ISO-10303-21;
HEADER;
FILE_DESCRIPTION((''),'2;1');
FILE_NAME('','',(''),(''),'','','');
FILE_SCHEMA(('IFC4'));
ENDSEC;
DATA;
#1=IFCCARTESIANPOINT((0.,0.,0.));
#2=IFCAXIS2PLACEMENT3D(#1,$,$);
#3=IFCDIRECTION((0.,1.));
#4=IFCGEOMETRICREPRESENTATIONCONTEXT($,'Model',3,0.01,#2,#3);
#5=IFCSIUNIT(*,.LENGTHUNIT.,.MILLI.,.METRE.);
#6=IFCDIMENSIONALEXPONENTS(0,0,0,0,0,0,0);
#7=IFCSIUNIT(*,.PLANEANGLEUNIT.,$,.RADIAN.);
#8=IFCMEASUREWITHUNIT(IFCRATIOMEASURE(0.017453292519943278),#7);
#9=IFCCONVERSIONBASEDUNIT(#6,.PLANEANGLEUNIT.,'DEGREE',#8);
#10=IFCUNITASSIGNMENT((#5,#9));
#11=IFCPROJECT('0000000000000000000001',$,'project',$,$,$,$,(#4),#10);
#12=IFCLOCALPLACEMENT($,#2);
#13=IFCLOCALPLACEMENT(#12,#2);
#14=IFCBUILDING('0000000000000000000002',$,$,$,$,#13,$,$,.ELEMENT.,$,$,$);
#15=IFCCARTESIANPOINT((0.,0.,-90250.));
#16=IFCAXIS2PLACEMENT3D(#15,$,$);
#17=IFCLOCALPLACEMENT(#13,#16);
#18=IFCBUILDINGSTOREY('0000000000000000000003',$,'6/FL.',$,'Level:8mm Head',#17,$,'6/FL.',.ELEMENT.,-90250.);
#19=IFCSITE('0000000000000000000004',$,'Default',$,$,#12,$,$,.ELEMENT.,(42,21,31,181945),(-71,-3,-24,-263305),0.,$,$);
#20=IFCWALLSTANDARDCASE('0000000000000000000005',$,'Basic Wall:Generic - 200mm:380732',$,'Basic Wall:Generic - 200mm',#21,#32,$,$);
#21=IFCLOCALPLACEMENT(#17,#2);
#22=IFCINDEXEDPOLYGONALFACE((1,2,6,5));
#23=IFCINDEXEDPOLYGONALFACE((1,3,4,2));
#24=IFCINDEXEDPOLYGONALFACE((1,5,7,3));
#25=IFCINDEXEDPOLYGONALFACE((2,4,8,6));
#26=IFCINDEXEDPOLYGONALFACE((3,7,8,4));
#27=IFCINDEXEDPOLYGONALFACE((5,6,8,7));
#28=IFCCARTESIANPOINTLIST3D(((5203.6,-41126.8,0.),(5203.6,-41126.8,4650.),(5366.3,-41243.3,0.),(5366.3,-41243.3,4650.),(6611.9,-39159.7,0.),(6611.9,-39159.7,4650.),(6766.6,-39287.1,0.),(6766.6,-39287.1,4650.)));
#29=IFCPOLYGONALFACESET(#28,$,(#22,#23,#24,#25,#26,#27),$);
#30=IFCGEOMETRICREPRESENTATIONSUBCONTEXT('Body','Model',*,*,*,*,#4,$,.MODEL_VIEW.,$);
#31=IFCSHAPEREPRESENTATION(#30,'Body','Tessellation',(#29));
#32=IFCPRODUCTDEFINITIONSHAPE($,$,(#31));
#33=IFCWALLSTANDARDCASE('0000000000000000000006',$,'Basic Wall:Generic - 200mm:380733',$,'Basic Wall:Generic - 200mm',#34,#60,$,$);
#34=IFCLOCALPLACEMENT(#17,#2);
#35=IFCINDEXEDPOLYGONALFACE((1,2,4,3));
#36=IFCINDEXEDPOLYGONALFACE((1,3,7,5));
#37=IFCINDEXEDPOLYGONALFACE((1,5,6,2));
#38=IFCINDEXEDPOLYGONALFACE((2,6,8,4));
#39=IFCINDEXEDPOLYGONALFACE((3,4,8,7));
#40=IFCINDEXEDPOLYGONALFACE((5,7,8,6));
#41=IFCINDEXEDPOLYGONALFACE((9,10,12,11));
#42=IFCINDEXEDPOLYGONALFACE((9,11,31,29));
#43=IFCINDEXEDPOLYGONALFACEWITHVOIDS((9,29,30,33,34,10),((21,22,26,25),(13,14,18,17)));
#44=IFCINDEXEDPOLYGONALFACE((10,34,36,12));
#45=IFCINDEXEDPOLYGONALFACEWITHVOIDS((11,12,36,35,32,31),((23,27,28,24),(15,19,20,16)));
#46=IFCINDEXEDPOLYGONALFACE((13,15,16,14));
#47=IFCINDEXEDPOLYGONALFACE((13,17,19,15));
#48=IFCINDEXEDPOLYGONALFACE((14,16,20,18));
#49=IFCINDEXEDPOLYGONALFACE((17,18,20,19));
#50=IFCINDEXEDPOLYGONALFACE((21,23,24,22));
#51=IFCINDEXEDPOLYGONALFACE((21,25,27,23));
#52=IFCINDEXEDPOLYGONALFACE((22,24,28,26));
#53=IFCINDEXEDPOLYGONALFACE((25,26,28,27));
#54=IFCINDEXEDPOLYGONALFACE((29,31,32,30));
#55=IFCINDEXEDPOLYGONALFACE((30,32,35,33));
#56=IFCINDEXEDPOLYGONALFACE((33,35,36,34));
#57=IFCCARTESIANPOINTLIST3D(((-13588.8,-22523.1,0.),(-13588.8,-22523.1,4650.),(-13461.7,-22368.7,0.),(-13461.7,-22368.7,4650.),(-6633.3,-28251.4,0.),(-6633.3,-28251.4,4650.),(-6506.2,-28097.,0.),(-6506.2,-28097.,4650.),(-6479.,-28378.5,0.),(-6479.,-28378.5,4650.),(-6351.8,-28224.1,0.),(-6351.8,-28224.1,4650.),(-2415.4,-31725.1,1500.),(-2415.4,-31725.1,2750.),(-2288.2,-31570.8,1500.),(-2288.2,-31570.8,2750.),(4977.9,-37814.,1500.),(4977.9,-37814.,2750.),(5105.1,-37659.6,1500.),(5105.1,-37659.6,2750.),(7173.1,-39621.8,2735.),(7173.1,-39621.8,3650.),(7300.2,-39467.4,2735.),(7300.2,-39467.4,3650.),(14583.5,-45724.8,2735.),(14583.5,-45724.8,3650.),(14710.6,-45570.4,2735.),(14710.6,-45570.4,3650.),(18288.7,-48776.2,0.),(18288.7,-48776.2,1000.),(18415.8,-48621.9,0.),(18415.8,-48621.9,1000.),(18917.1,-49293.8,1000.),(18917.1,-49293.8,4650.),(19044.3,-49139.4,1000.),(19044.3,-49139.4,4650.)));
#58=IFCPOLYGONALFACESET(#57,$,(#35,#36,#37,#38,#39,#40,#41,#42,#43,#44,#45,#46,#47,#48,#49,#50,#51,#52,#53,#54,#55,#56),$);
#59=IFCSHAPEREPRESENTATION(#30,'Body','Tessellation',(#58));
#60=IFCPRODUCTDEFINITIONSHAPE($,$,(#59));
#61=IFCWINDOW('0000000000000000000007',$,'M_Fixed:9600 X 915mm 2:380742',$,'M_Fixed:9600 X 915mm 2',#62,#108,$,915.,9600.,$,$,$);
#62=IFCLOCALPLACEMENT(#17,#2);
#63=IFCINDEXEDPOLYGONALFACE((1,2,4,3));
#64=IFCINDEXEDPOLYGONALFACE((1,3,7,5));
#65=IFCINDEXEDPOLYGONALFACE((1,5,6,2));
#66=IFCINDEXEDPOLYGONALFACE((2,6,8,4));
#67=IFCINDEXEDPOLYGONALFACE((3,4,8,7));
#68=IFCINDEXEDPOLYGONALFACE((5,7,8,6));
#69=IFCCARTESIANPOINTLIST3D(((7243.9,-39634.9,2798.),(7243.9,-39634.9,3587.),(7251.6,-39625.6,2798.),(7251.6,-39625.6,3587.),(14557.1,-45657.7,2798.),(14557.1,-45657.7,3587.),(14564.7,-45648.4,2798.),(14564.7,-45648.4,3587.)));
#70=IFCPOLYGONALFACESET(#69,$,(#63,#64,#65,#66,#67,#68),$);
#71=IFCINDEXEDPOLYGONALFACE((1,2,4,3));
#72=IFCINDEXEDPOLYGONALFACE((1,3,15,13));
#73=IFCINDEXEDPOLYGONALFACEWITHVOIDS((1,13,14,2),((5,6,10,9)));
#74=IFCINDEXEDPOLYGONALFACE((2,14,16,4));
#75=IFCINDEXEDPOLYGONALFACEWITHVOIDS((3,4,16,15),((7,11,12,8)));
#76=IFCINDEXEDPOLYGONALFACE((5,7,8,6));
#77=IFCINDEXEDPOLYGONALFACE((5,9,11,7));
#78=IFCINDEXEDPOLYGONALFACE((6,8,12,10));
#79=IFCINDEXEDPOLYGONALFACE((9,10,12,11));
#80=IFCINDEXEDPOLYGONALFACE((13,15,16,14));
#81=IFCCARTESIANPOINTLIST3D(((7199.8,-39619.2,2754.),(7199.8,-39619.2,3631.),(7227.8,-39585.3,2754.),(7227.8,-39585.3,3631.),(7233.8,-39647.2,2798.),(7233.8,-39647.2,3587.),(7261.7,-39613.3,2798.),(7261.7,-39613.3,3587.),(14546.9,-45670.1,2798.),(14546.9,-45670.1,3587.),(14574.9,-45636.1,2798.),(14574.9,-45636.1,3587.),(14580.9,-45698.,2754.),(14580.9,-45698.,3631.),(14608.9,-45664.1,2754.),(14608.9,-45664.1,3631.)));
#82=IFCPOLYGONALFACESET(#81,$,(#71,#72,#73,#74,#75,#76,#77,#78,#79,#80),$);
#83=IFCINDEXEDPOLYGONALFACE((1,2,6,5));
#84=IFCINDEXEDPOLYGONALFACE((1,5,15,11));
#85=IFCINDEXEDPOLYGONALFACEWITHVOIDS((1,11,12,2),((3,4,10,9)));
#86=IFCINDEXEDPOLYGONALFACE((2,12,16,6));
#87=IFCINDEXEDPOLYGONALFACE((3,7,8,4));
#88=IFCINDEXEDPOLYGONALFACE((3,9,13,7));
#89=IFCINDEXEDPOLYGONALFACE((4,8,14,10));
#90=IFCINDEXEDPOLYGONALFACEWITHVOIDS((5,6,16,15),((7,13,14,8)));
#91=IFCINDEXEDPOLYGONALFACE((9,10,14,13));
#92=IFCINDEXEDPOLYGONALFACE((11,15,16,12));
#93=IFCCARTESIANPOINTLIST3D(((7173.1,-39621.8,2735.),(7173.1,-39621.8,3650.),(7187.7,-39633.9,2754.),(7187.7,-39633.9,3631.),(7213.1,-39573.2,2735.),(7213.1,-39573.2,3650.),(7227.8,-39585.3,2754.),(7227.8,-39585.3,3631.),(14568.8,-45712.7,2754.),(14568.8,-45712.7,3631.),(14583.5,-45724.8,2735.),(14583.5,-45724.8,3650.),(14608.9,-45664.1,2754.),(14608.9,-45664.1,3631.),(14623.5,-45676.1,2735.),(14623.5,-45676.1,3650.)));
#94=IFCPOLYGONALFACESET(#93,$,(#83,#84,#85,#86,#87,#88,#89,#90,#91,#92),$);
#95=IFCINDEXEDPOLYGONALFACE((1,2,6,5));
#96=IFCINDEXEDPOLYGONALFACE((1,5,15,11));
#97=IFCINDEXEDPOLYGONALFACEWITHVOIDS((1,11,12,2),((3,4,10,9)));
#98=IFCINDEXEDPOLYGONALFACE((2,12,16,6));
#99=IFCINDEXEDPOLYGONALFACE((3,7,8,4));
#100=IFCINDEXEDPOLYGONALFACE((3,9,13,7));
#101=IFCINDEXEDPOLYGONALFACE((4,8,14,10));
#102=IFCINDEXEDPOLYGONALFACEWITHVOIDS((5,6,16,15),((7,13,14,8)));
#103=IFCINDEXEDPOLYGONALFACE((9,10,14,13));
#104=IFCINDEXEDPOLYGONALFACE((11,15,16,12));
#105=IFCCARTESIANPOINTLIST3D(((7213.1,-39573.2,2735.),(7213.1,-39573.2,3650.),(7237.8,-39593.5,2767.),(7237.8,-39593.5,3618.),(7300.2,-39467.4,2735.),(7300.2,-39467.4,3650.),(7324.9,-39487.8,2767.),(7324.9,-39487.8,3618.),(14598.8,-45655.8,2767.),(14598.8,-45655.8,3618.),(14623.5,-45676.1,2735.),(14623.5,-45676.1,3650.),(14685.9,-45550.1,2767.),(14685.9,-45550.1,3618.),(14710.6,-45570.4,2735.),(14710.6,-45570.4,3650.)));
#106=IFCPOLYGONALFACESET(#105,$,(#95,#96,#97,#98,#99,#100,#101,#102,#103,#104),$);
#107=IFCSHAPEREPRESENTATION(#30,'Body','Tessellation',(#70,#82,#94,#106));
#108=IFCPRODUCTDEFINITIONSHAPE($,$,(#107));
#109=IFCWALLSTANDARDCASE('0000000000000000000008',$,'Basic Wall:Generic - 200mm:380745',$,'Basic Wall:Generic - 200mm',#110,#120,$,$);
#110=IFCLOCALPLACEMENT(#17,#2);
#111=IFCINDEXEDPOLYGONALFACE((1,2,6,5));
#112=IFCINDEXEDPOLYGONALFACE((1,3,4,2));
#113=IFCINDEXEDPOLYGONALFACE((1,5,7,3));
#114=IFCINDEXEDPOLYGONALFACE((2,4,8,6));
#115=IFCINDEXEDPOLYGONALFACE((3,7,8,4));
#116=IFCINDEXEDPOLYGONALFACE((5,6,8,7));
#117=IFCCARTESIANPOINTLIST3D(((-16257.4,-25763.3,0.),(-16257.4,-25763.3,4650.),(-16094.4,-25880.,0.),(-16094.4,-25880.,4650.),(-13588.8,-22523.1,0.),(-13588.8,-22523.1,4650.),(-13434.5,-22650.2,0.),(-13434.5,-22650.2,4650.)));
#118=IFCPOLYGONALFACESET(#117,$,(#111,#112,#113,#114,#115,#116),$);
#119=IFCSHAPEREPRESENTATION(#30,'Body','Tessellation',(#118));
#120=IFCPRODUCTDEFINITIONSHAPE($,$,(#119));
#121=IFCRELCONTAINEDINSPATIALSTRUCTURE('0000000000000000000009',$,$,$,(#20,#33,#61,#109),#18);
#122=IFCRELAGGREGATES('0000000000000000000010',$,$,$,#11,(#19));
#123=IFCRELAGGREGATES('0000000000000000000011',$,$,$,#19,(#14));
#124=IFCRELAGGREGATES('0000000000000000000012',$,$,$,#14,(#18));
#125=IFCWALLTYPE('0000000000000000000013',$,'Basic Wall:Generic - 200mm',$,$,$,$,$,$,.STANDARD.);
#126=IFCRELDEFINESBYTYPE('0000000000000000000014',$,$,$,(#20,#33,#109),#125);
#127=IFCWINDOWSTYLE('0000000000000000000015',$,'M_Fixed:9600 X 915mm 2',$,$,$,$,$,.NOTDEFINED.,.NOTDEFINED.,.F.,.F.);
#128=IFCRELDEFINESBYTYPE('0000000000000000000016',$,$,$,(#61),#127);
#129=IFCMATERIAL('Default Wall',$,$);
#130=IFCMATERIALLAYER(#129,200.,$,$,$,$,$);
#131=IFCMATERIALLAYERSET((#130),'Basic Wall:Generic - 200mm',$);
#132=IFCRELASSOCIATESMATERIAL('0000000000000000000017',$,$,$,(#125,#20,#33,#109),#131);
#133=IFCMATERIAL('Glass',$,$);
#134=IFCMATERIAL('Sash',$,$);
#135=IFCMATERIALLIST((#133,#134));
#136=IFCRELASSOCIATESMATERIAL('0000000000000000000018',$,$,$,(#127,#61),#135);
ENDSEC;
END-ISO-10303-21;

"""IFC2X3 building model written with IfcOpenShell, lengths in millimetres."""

from ifc_helpers import new_model, entity, si_unit, converted_unit, direction, frame, frame_2d, origin, place, context, subcontext, project, spatial, polyline, rectangle, outline, extrude, source, transform, mapped, material, material_list, layer, layer_set, layer_usage, type_object, type_shapes, element, fill, save


model = new_model("IFC2X3")

# Units and contexts
model_context = context("Model", 3, precision=0.01, world=origin(), true_north=direction((0.0, 1.0)))
body_context = subcontext(model_context, "Body", "Model", "MODEL_VIEW")
ifc_project = project(units=[si_unit("LENGTHUNIT", "METRE", prefix="MILLI"), converted_unit("PLANEANGLEUNIT", "DEGREE", entity("IfcRatioMeasure", 0.017453292519943278), si_unit("PLANEANGLEUNIT", "RADIAN"), dimensions=[0, 0, 0, 0, 0, 0, 0])], contexts=[model_context])

# Site, building, storey
site_placement = place(None, origin())
site = spatial("IfcSite", under=ifc_project, at=site_placement, Name="Default", CompositionType="ELEMENT", RefLatitude=(42, 21, 31, 181945), RefLongitude=(-71, -3, -24, -263305), RefElevation=0.0)
building_placement = place(site_placement, origin())
building = spatial("IfcBuilding", under=site, at=building_placement, CompositionType="ELEMENT")
storey_placement = place(building_placement, frame((0.0, 0.0, -90250.0)))
storey = spatial("IfcBuildingStorey", under=building, at=storey_placement, Name="6/FL.", ObjectType="Level:8mm Head", LongName="6/FL.", CompositionType="ELEMENT", Elevation=-90250.0)

# Shared definitions
ifc_material_1 = material(Name="Default Wall")
ifc_layer = layer(ifc_material_1, 200.0)
ifc_layer_set = layer_set([ifc_layer], Name="Basic Wall:Generic - 200mm")
ifc_layer_usage = layer_usage(ifc_layer_set, "AXIS2", "NEGATIVE", 100.0)
wall_type = type_object("IfcWallType", Name="Basic Wall:Generic - 200mm", PredefinedType="STANDARD", material=ifc_layer_set)

# Shared definitions
ifc_material_2 = material(Name="Glass")
ifc_material_3 = material(Name="Sash")
ifc_material_list = material_list([ifc_material_2, ifc_material_3])

# Wall
wall_1_placement = place(storey_placement, frame((5285.0, -41185.1, 0.0), z_axis=(0.0, 0.0, 1.0), x_axis=(0.582098, 0.813119, 0.0)))
element("IfcWallStandardCase", 1, at=wall_1_placement, inside=storey, type_object=wall_type, material=ifc_layer_usage, Name="Basic Wall:Generic - 200mm:380732", ObjectType="Basic Wall:Generic - 200mm", context=body_context, shape_type="SweptSolid", body=[
    extrude(outline(polyline([(2405.7, -100.0), (2419.3, 100.0), (0.0, 100.0), (0.0, -100.0), (2405.7, -100.0)])), origin(), (0.0, 0.0, 1.0), 4650.0),
])

# Wall, openings, window
wall_2_placement = place(storey_placement, frame((-13525.3, -22445.9, 0.0), z_axis=(0.0, 0.0, 1.0), x_axis=(0.771917, -0.635723, 0.0)))
wall_2 = element("IfcWallStandardCase", 2, at=wall_2_placement, inside=storey, type_object=wall_type, material=ifc_layer_usage, Name="Basic Wall:Generic - 200mm:380733", ObjectType="Basic Wall:Generic - 200mm", context=body_context, shape_type="SweptSolid", body=[
    extrude(rectangle(XDim=42110.7, YDim=200.0, at=frame_2d((21055.3, 0.0), x_axis=(-1.0, 0.0))), origin(), (0.0, 0.0, 1.0), 4650.0),
])
opening_1_placement = place(storey_placement, frame((-13525.3, -22445.9, 0.0), z_axis=(0.0, 0.0, 1.0), x_axis=(0.771917, -0.635723, 0.0)))
element("IfcOpeningElement", 3, at=opening_1_placement, cuts=wall_2, ObjectType="Opening", context=body_context, shape_type="SweptSolid", body=[
    extrude(rectangle(XDim=4650.0, YDim=200.0, at=frame_2d((0.0, 0.0), x_axis=(1.0, 0.0))), frame((9210.7, 0.0, 2325.0), z_axis=(-1.0, 0.0, 0.0), x_axis=(0.0, 0.0, 1.0)), (0.0, 0.0, 1.0), 200.0),
])
opening_2_placement = place(wall_2_placement, origin())
element("IfcOpeningElement", 4, at=opening_2_placement, cuts=wall_2, ObjectType="Opening", context=body_context, shape_type="SweptSolid", body=[
    extrude(rectangle(XDim=1250.0, YDim=9577.8, at=frame_2d((0.0, 0.0), x_axis=(1.0, 0.0))), frame((19263.9, -100.0, 2125.0), z_axis=(0.0, 1.0, 0.0), x_axis=(0.0, 0.0, -1.0)), (0.0, 0.0, 1.0), 200.0),
])
opening_3_placement = place(wall_2_placement, frame((-3829.0, 25924.7, 0.0), z_axis=(0.0, 0.0, 1.0), x_axis=(0.771917, 0.635723, 0.0)))
element("IfcOpeningElement", 5, at=opening_3_placement, cuts=wall_2, ObjectType="Opening", context=body_context, shape_type="SweptSolid", body=[
    extrude(rectangle(XDim=1000.0, YDim=1010.1, at=frame_2d((0.0, 0.0), x_axis=(1.0, 0.0))), frame((18670.5, -49107.1, 500.0), z_axis=(0.635723, 0.771917, 0.0), x_axis=(0.0, 0.0, -1.0)), (0.0, 0.0, 1.0), 1012.7),
])
opening_4_placement = place(wall_2_placement, frame((36496.6, 100.0, 2735.0)))
opening_4 = element("IfcOpeningElement", 6, at=opening_4_placement, cuts=wall_2, ObjectType="Opening", context=body_context, shape_type="SweptSolid", body=[
    extrude(rectangle(XDim=915.0, YDim=9600.0, at=frame_2d((457.5, 4800.0), x_axis=(1.0, 0.0))), frame((0.0, 0.0, 0.0), z_axis=(0.0, -1.0, 0.0), x_axis=(0.0, 0.0, 1.0)), (0.0, 0.0, 1.0), 200.0),
])
window_style_1 = type_object("IfcWindowStyle", Name="M_Fixed:9600 X 915mm 2", ConstructionType="NOTDEFINED", OperationType="NOTDEFINED", ParameterTakesPrecedence=False, Sizeable=False, material=ifc_material_list)
shared_shape_1 = source(origin(), body_context, "Body", "SweptSolid", [
    extrude(rectangle(XDim=12.0, YDim=9474.0, at=frame_2d((0.0, 0.0), x_axis=(1.0, 0.0))), frame((4800.0, 159.0, 63.0), z_axis=(0.0, 0.0, 1.0), x_axis=(0.0, -1.0, 0.0)), (0.0, 0.0, 1.0), 789.0),
    extrude(outline(polyline([(-4781.0, -438.5), (4781.0, -438.5), (4781.0, 438.5), (-4781.0, 438.5), (-4781.0, -438.5)]), holes=[polyline([(-4737.0, -394.5), (-4737.0, 394.5), (4737.0, 394.5), (4737.0, -394.5), (-4737.0, -394.5)])]), frame((4800.0, 137.0, 457.5), z_axis=(0.0, 1.0, 0.0), x_axis=(1.0, 0.0, 0.0)), (0.0, 0.0, 1.0), 44.0),
    extrude(outline(polyline([(-4800.0, -457.5), (4800.0, -457.5), (4800.0, 457.5), (-4800.0, 457.5), (-4800.0, -457.5)]), holes=[polyline([(-4781.0, -438.5), (-4781.0, 438.5), (4781.0, 438.5), (4781.0, -438.5), (-4781.0, -438.5)])]), frame((4800.0, 137.0, 457.5), z_axis=(0.0, 1.0, 0.0), x_axis=(1.0, 0.0, 0.0)), (0.0, 0.0, 1.0), 63.0),
    extrude(outline(polyline([(-4800.0, -457.5), (4800.0, -457.5), (4800.0, 457.5), (-4800.0, 457.5), (-4800.0, -457.5)]), holes=[polyline([(-4768.0, -425.5), (-4768.0, 425.5), (4768.0, 425.5), (4768.0, -425.5), (-4768.0, -425.5)])]), frame((4800.0, 0.0, 457.5), z_axis=(0.0, 1.0, 0.0), x_axis=(1.0, 0.0, 0.0)), (0.0, 0.0, 1.0), 137.0),
])
type_shapes(window_style_1, [shared_shape_1])
window_1_placement = place(opening_4_placement, frame((0.0, 0.0, 0.0), z_axis=(0.0, 0.0, 1.0), x_axis=(-1.0, 0.0, 0.0)))
window_1 = element("IfcWindow", 7, at=window_1_placement, inside=storey, type_object=window_style_1, material=ifc_material_list, Name="M_Fixed:9600 X 915mm 2:380742", ObjectType="M_Fixed:9600 X 915mm 2", OverallHeight=915.0, OverallWidth=9600.0, context=body_context, shape_type="MappedRepresentation", body=[
    mapped(shared_shape_1, transform((0.0, 0.0, 0.0), scale=1.0)),
])
fill(opening_4, window_1)

# Wall
wall_3_placement = place(storey_placement, frame((-16180.2, -25826.8, 0.0), z_axis=(0.0, 0.0, 1.0), x_axis=(0.635723, 0.771917, 0.0)))
element("IfcWallStandardCase", 8, at=wall_3_placement, inside=storey, type_object=wall_type, material=ifc_layer_usage, Name="Basic Wall:Generic - 200mm:380745", ObjectType="Basic Wall:Generic - 200mm", context=body_context, shape_type="SweptSolid", body=[
    extrude(outline(polyline([(4197.6, -100.0), (4197.6, 100.0), (0.0, 100.0), (13.5, -100.0), (4197.6, -100.0)])), origin(), (0.0, 0.0, 1.0), 4650.0),
])

save(model, "model.ifc")
